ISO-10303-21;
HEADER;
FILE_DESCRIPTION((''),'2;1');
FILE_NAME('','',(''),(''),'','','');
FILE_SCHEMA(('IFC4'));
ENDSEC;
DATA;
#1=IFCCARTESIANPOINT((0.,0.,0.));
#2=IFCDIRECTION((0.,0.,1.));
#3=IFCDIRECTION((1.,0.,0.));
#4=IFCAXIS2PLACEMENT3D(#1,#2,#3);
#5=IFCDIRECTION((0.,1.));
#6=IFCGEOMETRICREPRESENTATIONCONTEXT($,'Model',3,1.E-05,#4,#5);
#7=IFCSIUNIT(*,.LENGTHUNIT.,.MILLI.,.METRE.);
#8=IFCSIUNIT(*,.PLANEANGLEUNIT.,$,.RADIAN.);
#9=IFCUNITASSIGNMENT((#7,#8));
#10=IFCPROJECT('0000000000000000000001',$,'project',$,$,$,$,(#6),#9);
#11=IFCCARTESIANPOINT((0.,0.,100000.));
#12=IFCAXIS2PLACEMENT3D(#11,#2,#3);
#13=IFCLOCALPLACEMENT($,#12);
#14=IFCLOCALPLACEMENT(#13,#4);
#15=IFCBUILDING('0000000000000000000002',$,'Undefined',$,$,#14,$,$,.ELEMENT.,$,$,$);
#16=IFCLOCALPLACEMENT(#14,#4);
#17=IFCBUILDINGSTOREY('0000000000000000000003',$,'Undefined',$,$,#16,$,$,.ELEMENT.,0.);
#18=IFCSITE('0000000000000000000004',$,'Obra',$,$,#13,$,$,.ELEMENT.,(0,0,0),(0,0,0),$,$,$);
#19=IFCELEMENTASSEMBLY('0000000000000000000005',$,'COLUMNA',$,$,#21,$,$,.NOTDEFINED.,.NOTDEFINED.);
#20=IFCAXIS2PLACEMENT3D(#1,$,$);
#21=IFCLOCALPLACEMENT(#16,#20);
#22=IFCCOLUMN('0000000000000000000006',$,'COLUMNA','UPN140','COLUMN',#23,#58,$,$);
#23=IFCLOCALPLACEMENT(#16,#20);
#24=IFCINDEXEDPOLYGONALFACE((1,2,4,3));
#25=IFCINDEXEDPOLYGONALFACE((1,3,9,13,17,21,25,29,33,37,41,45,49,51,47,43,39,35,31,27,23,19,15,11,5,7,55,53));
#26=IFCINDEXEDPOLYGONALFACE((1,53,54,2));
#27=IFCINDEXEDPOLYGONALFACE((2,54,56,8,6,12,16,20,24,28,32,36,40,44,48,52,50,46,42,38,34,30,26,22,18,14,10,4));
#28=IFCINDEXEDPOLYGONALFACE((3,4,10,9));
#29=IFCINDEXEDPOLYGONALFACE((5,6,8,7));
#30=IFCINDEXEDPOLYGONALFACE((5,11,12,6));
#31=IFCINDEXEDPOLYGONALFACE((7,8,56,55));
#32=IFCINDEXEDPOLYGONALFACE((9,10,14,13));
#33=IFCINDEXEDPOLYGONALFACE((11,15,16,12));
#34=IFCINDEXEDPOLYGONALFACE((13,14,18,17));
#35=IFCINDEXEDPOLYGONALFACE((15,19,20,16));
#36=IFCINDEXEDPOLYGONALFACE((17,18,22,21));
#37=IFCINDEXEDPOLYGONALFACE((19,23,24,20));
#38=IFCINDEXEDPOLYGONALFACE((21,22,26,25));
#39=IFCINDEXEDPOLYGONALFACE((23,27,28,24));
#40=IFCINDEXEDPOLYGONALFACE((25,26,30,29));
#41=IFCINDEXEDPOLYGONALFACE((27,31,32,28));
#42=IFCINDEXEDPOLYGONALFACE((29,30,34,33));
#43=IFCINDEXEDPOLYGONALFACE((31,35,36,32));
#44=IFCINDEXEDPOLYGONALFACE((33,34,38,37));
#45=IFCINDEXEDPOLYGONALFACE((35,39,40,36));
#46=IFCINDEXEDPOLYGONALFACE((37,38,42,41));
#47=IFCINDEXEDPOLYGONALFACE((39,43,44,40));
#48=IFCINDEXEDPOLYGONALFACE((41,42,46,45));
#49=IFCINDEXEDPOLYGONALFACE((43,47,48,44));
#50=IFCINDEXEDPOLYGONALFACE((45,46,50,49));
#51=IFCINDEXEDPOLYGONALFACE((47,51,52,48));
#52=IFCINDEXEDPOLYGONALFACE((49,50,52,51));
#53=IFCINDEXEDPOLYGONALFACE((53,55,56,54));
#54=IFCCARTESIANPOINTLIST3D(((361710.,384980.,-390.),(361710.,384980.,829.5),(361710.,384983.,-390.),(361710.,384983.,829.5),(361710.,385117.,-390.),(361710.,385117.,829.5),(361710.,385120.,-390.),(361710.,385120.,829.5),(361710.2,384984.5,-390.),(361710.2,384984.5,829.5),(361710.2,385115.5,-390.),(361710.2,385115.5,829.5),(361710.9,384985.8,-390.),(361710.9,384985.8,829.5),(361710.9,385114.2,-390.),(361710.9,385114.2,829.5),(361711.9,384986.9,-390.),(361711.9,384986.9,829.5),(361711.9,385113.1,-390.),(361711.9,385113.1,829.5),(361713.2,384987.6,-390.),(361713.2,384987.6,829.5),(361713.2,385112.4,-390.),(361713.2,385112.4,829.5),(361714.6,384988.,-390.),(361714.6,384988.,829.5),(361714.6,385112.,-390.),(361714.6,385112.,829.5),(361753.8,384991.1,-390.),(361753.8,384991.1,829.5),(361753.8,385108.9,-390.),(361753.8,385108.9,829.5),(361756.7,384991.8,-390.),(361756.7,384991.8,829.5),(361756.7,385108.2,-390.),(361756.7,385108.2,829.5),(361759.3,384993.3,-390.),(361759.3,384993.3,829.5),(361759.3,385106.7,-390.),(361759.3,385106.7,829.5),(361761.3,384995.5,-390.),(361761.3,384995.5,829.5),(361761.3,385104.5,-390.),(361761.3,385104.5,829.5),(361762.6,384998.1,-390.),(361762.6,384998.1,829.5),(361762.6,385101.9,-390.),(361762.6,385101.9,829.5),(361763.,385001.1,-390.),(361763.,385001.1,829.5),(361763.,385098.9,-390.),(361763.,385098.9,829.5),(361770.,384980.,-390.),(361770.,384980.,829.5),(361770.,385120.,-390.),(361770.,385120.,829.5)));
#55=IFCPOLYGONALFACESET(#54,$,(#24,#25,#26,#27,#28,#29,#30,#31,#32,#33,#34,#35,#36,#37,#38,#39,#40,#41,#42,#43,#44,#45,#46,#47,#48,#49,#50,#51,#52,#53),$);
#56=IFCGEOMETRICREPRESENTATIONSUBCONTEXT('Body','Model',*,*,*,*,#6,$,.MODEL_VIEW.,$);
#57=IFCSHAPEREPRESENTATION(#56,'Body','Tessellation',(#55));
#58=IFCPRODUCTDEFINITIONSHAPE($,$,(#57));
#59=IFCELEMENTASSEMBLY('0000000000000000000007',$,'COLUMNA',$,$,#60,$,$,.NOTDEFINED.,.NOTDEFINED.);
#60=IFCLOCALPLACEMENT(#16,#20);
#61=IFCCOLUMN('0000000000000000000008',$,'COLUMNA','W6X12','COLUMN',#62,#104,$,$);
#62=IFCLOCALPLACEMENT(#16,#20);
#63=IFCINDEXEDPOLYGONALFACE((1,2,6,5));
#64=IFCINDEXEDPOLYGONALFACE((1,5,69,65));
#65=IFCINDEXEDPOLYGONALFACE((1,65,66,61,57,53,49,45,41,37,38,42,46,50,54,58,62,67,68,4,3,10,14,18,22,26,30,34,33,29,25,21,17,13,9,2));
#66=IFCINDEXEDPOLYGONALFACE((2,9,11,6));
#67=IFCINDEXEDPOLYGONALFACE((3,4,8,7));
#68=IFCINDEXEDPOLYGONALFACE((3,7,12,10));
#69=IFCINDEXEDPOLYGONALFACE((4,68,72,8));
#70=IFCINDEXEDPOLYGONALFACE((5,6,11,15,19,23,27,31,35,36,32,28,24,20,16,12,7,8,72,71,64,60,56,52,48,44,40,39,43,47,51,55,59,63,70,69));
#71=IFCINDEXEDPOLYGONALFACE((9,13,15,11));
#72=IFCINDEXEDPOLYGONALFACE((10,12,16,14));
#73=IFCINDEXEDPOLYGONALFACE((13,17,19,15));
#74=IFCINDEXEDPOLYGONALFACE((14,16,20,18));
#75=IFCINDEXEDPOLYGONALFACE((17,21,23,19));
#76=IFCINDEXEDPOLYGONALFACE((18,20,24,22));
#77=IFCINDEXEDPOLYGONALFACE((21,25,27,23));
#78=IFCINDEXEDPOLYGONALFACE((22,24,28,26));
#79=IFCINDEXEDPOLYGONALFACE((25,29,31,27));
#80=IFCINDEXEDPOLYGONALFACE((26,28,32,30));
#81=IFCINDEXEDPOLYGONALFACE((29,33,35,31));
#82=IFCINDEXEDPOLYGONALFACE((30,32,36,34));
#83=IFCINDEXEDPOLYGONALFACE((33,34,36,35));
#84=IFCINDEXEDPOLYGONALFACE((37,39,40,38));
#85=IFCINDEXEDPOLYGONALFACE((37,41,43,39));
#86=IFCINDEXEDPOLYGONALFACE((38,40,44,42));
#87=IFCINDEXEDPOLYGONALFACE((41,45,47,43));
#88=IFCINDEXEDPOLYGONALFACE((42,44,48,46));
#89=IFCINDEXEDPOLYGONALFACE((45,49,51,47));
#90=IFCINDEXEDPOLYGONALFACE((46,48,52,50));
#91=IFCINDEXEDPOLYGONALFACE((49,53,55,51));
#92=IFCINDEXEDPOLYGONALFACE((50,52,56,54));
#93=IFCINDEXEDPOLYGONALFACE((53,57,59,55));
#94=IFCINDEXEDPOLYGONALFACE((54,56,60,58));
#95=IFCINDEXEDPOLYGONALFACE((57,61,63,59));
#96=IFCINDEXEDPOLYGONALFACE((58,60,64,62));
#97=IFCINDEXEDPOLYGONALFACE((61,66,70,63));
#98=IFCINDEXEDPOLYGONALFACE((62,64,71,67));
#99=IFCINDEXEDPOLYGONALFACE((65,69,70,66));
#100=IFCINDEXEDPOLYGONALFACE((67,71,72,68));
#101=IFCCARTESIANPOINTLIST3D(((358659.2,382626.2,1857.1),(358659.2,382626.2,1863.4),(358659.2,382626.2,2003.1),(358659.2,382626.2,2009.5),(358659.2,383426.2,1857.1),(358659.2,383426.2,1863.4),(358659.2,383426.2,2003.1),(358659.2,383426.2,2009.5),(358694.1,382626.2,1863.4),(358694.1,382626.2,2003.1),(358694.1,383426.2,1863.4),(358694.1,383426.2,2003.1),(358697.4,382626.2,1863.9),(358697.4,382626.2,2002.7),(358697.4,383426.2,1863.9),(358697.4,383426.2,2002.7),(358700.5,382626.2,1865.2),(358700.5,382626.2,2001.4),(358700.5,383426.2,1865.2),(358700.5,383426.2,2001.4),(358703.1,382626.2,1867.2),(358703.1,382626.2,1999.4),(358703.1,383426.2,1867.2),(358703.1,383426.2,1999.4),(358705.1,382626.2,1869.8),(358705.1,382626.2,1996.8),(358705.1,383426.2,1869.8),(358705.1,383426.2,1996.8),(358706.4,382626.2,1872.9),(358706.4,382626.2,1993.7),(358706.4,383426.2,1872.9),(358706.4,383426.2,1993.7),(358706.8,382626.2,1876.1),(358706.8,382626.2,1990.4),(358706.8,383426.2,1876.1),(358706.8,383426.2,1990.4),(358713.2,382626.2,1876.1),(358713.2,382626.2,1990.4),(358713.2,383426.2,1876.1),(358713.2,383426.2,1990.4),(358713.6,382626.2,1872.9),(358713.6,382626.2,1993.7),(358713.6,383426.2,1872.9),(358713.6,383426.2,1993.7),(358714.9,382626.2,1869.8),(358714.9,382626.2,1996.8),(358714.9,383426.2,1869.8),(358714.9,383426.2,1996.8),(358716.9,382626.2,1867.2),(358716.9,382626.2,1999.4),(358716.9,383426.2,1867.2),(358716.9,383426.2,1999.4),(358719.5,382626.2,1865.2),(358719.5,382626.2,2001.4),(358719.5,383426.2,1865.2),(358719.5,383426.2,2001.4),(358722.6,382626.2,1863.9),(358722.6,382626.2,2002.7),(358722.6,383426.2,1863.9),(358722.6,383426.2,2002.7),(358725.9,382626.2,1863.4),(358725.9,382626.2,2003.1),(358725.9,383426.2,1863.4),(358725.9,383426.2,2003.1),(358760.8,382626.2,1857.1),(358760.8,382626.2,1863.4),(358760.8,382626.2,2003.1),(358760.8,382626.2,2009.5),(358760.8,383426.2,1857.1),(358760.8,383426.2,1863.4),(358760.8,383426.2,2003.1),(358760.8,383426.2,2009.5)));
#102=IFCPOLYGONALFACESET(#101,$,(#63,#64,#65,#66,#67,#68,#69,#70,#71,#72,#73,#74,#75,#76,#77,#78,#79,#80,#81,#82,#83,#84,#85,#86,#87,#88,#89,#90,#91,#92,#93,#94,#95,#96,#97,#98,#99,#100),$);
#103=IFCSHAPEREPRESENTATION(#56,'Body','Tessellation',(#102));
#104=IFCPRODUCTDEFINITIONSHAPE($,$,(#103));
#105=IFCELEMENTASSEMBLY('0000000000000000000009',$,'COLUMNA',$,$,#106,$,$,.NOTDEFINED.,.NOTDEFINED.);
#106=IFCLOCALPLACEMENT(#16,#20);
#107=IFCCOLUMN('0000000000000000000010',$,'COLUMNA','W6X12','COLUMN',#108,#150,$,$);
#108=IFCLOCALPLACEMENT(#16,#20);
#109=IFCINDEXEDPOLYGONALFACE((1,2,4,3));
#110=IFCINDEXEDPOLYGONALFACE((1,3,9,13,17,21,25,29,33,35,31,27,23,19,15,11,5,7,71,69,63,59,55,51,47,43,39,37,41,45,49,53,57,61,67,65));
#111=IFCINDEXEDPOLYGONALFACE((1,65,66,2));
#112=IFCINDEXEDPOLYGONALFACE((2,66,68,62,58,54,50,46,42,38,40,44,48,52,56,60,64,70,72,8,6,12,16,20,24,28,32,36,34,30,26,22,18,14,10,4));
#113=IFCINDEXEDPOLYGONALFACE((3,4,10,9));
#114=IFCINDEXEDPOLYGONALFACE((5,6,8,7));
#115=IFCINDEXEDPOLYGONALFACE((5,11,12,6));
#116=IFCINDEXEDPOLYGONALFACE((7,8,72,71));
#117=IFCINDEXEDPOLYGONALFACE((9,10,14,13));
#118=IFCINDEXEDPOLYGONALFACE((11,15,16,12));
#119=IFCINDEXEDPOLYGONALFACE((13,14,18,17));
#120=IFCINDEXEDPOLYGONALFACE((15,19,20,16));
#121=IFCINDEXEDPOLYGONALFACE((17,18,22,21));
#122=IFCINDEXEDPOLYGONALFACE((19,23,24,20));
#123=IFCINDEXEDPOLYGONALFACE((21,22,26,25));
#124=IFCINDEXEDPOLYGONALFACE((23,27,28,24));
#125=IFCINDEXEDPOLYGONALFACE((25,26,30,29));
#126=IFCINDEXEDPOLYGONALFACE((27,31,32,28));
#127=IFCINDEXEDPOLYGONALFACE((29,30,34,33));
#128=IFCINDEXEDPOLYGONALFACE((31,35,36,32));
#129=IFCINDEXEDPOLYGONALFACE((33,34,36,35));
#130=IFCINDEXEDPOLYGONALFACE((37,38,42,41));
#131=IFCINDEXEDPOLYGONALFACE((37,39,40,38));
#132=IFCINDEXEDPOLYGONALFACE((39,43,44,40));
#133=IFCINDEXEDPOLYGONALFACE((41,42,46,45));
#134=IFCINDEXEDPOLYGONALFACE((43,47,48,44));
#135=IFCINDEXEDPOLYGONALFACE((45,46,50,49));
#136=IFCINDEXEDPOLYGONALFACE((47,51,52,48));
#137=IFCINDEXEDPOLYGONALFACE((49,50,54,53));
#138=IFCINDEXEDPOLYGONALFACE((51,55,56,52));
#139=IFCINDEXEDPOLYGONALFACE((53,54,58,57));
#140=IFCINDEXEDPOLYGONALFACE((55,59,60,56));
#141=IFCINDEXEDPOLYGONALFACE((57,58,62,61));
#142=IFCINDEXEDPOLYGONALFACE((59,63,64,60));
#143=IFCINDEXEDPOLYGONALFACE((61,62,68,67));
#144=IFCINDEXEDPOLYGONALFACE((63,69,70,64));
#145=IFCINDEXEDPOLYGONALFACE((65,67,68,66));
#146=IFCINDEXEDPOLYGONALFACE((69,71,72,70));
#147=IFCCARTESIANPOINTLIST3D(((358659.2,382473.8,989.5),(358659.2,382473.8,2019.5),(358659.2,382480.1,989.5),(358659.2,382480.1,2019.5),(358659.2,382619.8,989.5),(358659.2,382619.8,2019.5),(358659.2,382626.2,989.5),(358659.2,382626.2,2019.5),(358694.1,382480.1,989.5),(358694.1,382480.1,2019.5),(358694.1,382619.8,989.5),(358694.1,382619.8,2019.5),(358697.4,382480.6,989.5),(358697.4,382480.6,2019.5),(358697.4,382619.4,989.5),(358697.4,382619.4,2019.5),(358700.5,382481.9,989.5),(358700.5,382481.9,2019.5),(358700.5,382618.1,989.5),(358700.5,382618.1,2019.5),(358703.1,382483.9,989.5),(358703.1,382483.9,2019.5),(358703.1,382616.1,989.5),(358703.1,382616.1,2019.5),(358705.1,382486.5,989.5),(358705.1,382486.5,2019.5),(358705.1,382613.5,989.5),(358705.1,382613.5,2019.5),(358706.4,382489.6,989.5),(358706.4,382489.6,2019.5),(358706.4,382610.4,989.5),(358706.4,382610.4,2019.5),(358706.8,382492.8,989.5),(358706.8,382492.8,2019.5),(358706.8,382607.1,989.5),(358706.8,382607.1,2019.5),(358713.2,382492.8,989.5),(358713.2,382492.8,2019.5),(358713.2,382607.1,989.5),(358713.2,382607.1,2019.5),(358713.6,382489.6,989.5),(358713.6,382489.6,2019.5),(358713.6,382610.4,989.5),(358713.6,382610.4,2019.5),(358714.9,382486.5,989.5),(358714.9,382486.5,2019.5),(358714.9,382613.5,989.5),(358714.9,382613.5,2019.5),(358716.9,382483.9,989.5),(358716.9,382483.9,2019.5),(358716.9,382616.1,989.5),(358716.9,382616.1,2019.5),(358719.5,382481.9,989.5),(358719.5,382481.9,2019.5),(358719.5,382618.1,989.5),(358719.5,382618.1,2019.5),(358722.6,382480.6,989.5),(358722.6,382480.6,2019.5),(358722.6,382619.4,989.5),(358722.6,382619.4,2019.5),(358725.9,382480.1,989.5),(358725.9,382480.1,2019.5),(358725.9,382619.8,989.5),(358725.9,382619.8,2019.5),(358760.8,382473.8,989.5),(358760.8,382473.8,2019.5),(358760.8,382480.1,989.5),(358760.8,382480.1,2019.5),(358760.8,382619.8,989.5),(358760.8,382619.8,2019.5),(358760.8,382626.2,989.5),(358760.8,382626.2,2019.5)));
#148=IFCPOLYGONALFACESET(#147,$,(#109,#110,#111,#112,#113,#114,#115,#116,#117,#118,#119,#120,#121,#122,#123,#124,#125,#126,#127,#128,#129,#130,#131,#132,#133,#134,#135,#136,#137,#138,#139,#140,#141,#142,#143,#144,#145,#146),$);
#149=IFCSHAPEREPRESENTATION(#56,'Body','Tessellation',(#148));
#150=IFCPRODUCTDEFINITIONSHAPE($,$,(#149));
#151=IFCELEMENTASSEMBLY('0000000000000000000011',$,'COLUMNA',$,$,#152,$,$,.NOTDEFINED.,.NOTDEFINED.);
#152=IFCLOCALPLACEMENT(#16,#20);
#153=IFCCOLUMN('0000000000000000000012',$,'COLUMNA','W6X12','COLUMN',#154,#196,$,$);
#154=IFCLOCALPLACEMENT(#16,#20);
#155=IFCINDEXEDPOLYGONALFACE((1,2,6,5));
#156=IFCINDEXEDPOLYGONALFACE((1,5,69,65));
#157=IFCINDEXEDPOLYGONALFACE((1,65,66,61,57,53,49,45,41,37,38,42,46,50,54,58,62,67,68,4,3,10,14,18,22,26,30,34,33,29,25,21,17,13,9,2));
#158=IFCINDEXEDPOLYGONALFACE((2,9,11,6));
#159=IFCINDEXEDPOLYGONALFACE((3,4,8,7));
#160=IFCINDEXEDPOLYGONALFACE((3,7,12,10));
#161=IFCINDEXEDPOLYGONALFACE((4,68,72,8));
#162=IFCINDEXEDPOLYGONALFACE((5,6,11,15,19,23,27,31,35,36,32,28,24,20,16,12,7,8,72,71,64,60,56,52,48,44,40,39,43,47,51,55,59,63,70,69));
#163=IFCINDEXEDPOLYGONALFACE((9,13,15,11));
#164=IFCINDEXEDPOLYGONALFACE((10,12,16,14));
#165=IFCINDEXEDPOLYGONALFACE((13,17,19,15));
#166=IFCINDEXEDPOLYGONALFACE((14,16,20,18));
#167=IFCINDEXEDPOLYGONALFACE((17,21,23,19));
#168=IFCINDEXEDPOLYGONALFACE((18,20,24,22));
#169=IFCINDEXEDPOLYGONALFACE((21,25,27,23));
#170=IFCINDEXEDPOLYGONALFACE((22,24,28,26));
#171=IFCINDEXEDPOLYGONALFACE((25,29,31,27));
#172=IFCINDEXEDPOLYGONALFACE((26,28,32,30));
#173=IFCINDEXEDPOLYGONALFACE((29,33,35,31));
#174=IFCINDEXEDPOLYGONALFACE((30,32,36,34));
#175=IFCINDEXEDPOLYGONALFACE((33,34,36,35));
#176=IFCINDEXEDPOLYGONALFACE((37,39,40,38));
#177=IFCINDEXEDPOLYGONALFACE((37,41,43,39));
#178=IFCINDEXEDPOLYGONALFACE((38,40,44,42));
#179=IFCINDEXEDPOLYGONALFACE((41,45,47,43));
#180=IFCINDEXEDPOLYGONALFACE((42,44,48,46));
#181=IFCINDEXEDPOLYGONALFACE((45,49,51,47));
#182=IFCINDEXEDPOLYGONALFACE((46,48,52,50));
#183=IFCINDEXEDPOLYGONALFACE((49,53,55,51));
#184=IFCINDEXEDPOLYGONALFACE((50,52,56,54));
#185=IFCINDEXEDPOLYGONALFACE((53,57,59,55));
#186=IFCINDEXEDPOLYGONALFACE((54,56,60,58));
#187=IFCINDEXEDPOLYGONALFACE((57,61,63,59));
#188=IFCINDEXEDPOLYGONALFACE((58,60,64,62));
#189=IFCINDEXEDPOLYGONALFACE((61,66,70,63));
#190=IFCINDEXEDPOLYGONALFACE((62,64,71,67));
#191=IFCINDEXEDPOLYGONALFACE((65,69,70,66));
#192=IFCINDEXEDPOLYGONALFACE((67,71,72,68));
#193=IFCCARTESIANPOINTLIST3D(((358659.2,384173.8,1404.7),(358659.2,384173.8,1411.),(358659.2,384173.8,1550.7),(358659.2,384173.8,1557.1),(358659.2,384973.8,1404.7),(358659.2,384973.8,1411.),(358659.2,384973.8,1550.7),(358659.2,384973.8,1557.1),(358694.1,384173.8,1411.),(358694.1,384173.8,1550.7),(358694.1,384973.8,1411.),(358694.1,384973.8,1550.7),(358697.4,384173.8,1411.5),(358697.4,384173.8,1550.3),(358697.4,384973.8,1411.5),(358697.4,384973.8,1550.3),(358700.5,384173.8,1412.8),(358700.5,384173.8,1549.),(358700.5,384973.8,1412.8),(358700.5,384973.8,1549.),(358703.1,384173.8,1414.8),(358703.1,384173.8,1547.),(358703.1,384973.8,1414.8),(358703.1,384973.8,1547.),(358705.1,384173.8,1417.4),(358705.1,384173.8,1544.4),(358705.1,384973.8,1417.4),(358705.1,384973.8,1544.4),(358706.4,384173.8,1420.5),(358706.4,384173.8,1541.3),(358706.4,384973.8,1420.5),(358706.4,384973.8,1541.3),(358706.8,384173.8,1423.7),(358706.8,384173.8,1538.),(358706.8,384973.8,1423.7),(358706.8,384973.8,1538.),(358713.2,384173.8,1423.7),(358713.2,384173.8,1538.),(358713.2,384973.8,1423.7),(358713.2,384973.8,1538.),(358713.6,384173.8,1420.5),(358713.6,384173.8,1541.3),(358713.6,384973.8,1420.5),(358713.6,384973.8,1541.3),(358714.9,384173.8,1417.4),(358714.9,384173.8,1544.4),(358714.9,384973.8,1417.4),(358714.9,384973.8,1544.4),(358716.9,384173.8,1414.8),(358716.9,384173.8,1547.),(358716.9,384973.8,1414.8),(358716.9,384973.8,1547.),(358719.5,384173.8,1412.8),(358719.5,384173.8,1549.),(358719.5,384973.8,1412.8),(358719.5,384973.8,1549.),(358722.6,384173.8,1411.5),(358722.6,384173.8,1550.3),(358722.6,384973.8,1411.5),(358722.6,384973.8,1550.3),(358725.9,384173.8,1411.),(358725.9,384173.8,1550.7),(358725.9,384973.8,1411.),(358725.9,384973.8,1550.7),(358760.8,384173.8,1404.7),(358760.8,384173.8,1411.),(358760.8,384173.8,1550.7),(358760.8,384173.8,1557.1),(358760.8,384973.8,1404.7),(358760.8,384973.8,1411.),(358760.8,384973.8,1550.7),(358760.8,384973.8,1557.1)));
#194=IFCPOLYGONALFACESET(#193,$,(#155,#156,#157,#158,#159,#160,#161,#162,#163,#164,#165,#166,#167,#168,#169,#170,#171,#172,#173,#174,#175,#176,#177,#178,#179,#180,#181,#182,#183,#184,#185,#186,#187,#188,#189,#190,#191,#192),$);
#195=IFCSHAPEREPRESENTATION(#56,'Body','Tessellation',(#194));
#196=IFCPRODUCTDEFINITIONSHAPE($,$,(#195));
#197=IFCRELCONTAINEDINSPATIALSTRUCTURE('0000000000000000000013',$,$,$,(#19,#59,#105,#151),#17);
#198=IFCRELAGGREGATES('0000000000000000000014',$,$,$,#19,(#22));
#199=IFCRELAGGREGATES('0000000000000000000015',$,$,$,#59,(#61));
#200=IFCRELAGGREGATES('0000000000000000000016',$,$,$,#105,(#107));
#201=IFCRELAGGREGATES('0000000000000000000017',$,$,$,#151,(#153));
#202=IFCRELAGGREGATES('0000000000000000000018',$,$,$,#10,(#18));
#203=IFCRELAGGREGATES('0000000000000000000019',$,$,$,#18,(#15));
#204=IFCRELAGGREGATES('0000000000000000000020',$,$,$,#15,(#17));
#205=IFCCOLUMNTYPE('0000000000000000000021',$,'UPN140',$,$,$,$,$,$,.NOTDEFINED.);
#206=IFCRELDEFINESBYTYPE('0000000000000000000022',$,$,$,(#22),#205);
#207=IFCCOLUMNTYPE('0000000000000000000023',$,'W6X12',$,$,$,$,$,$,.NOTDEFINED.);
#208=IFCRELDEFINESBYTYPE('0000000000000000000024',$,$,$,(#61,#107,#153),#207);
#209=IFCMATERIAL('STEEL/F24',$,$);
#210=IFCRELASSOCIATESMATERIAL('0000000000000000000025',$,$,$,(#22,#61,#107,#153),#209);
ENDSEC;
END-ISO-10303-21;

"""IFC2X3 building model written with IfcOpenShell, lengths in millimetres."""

from ifc_helpers import new_model, si_unit, direction, frame, origin_with_axes, origin_2d_with_axis, place, context, subcontext, project, spatial, i_section, u_section, extrude, material, type_object, element, aggregate, save


model = new_model("IFC2X3")

# Units and contexts
model_context = context("Model", 3, precision=1e-05, world=origin_with_axes(), true_north=direction((0.0, 1.0)))
body_context = subcontext(model_context, "Body", "Model", "MODEL_VIEW")
ifc_project = project(units=[si_unit("LENGTHUNIT", "METRE", prefix="MILLI"), si_unit("PLANEANGLEUNIT", "RADIAN")], contexts=[model_context])

# Site, building, storey
site_placement = place(None, frame((0.0, 0.0, 100000.0), z_axis=(0.0, 0.0, 1.0), x_axis=(1.0, 0.0, 0.0)))
site = spatial("IfcSite", under=ifc_project, at=site_placement, Name="Obra", CompositionType="ELEMENT", RefLatitude=(0, 0, 0), RefLongitude=(0, 0, 0))
building_placement = place(site_placement, origin_with_axes())
building = spatial("IfcBuilding", under=site, at=building_placement, Name="Undefined", CompositionType="ELEMENT")
storey_placement = place(building_placement, origin_with_axes())
storey = spatial("IfcBuildingStorey", under=building, at=storey_placement, Name="Undefined", CompositionType="ELEMENT", Elevation=0.0)

# Element assemblies, columns
ifc_material_1 = material(Name="STEEL/F24")
column_type_1 = type_object("IfcColumnType", Name="UPN140", PredefinedType="NOTDEFINED")
assembly_1_placement = place(storey_placement, origin_with_axes())
assembly_1 = element("IfcElementAssembly", 1, at=assembly_1_placement, inside=storey, Name="COLUMNA", AssemblyPlace="NOTDEFINED", PredefinedType="NOTDEFINED")
column_1_placement = place(assembly_1_placement, frame((361740.0, 385050.0, -390.0), z_axis=(0.0, 0.0, 1.0), x_axis=(0.0, 1.0, 0.0)))
column_1 = element("IfcColumn", 2, at=column_1_placement, type_object=column_type_1, material=ifc_material_1, Name="COLUMNA", Description="UPN140", ObjectType="COLUMN", context=body_context, shape_type="SweptSolid", body=[
    extrude(u_section(Depth=140.0, FlangeWidth=60.0, WebThickness=7.0, FlangeThickness=10.0, FilletRadius=10.0, EdgeRadius=5.0, FlangeSlope=0.07983, at=origin_2d_with_axis()), frame((0.0, 0.0, 1219.5), z_axis=(0.0, 0.0, -1.0), x_axis=(0.0, 1.0, 0.0)), (0.0, 0.0, 1.0), 1219.5),
])
aggregate(assembly_1, [column_1])
assembly_2_placement = place(storey_placement, origin_with_axes())
assembly_2 = element("IfcElementAssembly", 3, at=assembly_2_placement, inside=storey, Name="COLUMNA", AssemblyPlace="NOTDEFINED", PredefinedType="NOTDEFINED")
column_type_2 = type_object("IfcColumnType", Name="W6X12", PredefinedType="NOTDEFINED")
column_2_placement = place(assembly_2_placement, frame((358710.0, 382626.2, 1933.3), z_axis=(0.0, 1.0, 0.0), x_axis=(0.0, 0.0, -1.0)))
column_2 = element("IfcColumn", 4, at=column_2_placement, type_object=column_type_2, material=ifc_material_1, Name="COLUMNA", Description="W6X12", ObjectType="COLUMN", context=body_context, shape_type="SweptSolid", body=[
    extrude(i_section(OverallWidth=101.6, OverallDepth=152.4, WebThickness=6.3, FlangeThickness=6.3, FilletRadius=12.7, at=origin_2d_with_axis()), frame((0.0, 0.0, 800.0), z_axis=(0.0, 0.0, -1.0), x_axis=(0.0, 1.0, 0.0)), (0.0, 0.0, 1.0), 800.0),
])
aggregate(assembly_2, [column_2])
assembly_3_placement = place(storey_placement, origin_with_axes())
assembly_3 = element("IfcElementAssembly", 5, at=assembly_3_placement, inside=storey, Name="COLUMNA", AssemblyPlace="NOTDEFINED", PredefinedType="NOTDEFINED")
column_3_placement = place(assembly_3_placement, frame((358710.0, 382550.0, 989.5), z_axis=(0.0, 0.0, 1.0), x_axis=(0.0, -1.0, 0.0)))
column_3 = element("IfcColumn", 6, at=column_3_placement, type_object=column_type_2, material=ifc_material_1, Name="COLUMNA", Description="W6X12", ObjectType="COLUMN", context=body_context, shape_type="SweptSolid", body=[
    extrude(i_section(OverallWidth=101.6, OverallDepth=152.4, WebThickness=6.3, FlangeThickness=6.3, FilletRadius=12.7, at=origin_2d_with_axis()), frame((0.0, 0.0, 1030.0), z_axis=(0.0, 0.0, -1.0), x_axis=(0.0, 1.0, 0.0)), (0.0, 0.0, 1.0), 1030.0),
])
aggregate(assembly_3, [column_3])
assembly_4_placement = place(storey_placement, origin_with_axes())
assembly_4 = element("IfcElementAssembly", 7, at=assembly_4_placement, inside=storey, Name="COLUMNA", AssemblyPlace="NOTDEFINED", PredefinedType="NOTDEFINED")
column_4_placement = place(assembly_4_placement, frame((358710.0, 384973.8, 1480.9), z_axis=(0.0, -1.0, 0.0), x_axis=(0.0, 0.0, -1.0)))
column_4 = element("IfcColumn", 8, at=column_4_placement, type_object=column_type_2, material=ifc_material_1, Name="COLUMNA", Description="W6X12", ObjectType="COLUMN", context=body_context, shape_type="SweptSolid", body=[
    extrude(i_section(OverallWidth=101.6, OverallDepth=152.4, WebThickness=6.3, FlangeThickness=6.3, FilletRadius=12.7, at=origin_2d_with_axis()), frame((0.0, 0.0, 800.0), z_axis=(0.0, 0.0, -1.0), x_axis=(0.0, 1.0, 0.0)), (0.0, 0.0, 1.0), 800.0),
])
aggregate(assembly_4, [column_4])

save(model, "model.ifc")
